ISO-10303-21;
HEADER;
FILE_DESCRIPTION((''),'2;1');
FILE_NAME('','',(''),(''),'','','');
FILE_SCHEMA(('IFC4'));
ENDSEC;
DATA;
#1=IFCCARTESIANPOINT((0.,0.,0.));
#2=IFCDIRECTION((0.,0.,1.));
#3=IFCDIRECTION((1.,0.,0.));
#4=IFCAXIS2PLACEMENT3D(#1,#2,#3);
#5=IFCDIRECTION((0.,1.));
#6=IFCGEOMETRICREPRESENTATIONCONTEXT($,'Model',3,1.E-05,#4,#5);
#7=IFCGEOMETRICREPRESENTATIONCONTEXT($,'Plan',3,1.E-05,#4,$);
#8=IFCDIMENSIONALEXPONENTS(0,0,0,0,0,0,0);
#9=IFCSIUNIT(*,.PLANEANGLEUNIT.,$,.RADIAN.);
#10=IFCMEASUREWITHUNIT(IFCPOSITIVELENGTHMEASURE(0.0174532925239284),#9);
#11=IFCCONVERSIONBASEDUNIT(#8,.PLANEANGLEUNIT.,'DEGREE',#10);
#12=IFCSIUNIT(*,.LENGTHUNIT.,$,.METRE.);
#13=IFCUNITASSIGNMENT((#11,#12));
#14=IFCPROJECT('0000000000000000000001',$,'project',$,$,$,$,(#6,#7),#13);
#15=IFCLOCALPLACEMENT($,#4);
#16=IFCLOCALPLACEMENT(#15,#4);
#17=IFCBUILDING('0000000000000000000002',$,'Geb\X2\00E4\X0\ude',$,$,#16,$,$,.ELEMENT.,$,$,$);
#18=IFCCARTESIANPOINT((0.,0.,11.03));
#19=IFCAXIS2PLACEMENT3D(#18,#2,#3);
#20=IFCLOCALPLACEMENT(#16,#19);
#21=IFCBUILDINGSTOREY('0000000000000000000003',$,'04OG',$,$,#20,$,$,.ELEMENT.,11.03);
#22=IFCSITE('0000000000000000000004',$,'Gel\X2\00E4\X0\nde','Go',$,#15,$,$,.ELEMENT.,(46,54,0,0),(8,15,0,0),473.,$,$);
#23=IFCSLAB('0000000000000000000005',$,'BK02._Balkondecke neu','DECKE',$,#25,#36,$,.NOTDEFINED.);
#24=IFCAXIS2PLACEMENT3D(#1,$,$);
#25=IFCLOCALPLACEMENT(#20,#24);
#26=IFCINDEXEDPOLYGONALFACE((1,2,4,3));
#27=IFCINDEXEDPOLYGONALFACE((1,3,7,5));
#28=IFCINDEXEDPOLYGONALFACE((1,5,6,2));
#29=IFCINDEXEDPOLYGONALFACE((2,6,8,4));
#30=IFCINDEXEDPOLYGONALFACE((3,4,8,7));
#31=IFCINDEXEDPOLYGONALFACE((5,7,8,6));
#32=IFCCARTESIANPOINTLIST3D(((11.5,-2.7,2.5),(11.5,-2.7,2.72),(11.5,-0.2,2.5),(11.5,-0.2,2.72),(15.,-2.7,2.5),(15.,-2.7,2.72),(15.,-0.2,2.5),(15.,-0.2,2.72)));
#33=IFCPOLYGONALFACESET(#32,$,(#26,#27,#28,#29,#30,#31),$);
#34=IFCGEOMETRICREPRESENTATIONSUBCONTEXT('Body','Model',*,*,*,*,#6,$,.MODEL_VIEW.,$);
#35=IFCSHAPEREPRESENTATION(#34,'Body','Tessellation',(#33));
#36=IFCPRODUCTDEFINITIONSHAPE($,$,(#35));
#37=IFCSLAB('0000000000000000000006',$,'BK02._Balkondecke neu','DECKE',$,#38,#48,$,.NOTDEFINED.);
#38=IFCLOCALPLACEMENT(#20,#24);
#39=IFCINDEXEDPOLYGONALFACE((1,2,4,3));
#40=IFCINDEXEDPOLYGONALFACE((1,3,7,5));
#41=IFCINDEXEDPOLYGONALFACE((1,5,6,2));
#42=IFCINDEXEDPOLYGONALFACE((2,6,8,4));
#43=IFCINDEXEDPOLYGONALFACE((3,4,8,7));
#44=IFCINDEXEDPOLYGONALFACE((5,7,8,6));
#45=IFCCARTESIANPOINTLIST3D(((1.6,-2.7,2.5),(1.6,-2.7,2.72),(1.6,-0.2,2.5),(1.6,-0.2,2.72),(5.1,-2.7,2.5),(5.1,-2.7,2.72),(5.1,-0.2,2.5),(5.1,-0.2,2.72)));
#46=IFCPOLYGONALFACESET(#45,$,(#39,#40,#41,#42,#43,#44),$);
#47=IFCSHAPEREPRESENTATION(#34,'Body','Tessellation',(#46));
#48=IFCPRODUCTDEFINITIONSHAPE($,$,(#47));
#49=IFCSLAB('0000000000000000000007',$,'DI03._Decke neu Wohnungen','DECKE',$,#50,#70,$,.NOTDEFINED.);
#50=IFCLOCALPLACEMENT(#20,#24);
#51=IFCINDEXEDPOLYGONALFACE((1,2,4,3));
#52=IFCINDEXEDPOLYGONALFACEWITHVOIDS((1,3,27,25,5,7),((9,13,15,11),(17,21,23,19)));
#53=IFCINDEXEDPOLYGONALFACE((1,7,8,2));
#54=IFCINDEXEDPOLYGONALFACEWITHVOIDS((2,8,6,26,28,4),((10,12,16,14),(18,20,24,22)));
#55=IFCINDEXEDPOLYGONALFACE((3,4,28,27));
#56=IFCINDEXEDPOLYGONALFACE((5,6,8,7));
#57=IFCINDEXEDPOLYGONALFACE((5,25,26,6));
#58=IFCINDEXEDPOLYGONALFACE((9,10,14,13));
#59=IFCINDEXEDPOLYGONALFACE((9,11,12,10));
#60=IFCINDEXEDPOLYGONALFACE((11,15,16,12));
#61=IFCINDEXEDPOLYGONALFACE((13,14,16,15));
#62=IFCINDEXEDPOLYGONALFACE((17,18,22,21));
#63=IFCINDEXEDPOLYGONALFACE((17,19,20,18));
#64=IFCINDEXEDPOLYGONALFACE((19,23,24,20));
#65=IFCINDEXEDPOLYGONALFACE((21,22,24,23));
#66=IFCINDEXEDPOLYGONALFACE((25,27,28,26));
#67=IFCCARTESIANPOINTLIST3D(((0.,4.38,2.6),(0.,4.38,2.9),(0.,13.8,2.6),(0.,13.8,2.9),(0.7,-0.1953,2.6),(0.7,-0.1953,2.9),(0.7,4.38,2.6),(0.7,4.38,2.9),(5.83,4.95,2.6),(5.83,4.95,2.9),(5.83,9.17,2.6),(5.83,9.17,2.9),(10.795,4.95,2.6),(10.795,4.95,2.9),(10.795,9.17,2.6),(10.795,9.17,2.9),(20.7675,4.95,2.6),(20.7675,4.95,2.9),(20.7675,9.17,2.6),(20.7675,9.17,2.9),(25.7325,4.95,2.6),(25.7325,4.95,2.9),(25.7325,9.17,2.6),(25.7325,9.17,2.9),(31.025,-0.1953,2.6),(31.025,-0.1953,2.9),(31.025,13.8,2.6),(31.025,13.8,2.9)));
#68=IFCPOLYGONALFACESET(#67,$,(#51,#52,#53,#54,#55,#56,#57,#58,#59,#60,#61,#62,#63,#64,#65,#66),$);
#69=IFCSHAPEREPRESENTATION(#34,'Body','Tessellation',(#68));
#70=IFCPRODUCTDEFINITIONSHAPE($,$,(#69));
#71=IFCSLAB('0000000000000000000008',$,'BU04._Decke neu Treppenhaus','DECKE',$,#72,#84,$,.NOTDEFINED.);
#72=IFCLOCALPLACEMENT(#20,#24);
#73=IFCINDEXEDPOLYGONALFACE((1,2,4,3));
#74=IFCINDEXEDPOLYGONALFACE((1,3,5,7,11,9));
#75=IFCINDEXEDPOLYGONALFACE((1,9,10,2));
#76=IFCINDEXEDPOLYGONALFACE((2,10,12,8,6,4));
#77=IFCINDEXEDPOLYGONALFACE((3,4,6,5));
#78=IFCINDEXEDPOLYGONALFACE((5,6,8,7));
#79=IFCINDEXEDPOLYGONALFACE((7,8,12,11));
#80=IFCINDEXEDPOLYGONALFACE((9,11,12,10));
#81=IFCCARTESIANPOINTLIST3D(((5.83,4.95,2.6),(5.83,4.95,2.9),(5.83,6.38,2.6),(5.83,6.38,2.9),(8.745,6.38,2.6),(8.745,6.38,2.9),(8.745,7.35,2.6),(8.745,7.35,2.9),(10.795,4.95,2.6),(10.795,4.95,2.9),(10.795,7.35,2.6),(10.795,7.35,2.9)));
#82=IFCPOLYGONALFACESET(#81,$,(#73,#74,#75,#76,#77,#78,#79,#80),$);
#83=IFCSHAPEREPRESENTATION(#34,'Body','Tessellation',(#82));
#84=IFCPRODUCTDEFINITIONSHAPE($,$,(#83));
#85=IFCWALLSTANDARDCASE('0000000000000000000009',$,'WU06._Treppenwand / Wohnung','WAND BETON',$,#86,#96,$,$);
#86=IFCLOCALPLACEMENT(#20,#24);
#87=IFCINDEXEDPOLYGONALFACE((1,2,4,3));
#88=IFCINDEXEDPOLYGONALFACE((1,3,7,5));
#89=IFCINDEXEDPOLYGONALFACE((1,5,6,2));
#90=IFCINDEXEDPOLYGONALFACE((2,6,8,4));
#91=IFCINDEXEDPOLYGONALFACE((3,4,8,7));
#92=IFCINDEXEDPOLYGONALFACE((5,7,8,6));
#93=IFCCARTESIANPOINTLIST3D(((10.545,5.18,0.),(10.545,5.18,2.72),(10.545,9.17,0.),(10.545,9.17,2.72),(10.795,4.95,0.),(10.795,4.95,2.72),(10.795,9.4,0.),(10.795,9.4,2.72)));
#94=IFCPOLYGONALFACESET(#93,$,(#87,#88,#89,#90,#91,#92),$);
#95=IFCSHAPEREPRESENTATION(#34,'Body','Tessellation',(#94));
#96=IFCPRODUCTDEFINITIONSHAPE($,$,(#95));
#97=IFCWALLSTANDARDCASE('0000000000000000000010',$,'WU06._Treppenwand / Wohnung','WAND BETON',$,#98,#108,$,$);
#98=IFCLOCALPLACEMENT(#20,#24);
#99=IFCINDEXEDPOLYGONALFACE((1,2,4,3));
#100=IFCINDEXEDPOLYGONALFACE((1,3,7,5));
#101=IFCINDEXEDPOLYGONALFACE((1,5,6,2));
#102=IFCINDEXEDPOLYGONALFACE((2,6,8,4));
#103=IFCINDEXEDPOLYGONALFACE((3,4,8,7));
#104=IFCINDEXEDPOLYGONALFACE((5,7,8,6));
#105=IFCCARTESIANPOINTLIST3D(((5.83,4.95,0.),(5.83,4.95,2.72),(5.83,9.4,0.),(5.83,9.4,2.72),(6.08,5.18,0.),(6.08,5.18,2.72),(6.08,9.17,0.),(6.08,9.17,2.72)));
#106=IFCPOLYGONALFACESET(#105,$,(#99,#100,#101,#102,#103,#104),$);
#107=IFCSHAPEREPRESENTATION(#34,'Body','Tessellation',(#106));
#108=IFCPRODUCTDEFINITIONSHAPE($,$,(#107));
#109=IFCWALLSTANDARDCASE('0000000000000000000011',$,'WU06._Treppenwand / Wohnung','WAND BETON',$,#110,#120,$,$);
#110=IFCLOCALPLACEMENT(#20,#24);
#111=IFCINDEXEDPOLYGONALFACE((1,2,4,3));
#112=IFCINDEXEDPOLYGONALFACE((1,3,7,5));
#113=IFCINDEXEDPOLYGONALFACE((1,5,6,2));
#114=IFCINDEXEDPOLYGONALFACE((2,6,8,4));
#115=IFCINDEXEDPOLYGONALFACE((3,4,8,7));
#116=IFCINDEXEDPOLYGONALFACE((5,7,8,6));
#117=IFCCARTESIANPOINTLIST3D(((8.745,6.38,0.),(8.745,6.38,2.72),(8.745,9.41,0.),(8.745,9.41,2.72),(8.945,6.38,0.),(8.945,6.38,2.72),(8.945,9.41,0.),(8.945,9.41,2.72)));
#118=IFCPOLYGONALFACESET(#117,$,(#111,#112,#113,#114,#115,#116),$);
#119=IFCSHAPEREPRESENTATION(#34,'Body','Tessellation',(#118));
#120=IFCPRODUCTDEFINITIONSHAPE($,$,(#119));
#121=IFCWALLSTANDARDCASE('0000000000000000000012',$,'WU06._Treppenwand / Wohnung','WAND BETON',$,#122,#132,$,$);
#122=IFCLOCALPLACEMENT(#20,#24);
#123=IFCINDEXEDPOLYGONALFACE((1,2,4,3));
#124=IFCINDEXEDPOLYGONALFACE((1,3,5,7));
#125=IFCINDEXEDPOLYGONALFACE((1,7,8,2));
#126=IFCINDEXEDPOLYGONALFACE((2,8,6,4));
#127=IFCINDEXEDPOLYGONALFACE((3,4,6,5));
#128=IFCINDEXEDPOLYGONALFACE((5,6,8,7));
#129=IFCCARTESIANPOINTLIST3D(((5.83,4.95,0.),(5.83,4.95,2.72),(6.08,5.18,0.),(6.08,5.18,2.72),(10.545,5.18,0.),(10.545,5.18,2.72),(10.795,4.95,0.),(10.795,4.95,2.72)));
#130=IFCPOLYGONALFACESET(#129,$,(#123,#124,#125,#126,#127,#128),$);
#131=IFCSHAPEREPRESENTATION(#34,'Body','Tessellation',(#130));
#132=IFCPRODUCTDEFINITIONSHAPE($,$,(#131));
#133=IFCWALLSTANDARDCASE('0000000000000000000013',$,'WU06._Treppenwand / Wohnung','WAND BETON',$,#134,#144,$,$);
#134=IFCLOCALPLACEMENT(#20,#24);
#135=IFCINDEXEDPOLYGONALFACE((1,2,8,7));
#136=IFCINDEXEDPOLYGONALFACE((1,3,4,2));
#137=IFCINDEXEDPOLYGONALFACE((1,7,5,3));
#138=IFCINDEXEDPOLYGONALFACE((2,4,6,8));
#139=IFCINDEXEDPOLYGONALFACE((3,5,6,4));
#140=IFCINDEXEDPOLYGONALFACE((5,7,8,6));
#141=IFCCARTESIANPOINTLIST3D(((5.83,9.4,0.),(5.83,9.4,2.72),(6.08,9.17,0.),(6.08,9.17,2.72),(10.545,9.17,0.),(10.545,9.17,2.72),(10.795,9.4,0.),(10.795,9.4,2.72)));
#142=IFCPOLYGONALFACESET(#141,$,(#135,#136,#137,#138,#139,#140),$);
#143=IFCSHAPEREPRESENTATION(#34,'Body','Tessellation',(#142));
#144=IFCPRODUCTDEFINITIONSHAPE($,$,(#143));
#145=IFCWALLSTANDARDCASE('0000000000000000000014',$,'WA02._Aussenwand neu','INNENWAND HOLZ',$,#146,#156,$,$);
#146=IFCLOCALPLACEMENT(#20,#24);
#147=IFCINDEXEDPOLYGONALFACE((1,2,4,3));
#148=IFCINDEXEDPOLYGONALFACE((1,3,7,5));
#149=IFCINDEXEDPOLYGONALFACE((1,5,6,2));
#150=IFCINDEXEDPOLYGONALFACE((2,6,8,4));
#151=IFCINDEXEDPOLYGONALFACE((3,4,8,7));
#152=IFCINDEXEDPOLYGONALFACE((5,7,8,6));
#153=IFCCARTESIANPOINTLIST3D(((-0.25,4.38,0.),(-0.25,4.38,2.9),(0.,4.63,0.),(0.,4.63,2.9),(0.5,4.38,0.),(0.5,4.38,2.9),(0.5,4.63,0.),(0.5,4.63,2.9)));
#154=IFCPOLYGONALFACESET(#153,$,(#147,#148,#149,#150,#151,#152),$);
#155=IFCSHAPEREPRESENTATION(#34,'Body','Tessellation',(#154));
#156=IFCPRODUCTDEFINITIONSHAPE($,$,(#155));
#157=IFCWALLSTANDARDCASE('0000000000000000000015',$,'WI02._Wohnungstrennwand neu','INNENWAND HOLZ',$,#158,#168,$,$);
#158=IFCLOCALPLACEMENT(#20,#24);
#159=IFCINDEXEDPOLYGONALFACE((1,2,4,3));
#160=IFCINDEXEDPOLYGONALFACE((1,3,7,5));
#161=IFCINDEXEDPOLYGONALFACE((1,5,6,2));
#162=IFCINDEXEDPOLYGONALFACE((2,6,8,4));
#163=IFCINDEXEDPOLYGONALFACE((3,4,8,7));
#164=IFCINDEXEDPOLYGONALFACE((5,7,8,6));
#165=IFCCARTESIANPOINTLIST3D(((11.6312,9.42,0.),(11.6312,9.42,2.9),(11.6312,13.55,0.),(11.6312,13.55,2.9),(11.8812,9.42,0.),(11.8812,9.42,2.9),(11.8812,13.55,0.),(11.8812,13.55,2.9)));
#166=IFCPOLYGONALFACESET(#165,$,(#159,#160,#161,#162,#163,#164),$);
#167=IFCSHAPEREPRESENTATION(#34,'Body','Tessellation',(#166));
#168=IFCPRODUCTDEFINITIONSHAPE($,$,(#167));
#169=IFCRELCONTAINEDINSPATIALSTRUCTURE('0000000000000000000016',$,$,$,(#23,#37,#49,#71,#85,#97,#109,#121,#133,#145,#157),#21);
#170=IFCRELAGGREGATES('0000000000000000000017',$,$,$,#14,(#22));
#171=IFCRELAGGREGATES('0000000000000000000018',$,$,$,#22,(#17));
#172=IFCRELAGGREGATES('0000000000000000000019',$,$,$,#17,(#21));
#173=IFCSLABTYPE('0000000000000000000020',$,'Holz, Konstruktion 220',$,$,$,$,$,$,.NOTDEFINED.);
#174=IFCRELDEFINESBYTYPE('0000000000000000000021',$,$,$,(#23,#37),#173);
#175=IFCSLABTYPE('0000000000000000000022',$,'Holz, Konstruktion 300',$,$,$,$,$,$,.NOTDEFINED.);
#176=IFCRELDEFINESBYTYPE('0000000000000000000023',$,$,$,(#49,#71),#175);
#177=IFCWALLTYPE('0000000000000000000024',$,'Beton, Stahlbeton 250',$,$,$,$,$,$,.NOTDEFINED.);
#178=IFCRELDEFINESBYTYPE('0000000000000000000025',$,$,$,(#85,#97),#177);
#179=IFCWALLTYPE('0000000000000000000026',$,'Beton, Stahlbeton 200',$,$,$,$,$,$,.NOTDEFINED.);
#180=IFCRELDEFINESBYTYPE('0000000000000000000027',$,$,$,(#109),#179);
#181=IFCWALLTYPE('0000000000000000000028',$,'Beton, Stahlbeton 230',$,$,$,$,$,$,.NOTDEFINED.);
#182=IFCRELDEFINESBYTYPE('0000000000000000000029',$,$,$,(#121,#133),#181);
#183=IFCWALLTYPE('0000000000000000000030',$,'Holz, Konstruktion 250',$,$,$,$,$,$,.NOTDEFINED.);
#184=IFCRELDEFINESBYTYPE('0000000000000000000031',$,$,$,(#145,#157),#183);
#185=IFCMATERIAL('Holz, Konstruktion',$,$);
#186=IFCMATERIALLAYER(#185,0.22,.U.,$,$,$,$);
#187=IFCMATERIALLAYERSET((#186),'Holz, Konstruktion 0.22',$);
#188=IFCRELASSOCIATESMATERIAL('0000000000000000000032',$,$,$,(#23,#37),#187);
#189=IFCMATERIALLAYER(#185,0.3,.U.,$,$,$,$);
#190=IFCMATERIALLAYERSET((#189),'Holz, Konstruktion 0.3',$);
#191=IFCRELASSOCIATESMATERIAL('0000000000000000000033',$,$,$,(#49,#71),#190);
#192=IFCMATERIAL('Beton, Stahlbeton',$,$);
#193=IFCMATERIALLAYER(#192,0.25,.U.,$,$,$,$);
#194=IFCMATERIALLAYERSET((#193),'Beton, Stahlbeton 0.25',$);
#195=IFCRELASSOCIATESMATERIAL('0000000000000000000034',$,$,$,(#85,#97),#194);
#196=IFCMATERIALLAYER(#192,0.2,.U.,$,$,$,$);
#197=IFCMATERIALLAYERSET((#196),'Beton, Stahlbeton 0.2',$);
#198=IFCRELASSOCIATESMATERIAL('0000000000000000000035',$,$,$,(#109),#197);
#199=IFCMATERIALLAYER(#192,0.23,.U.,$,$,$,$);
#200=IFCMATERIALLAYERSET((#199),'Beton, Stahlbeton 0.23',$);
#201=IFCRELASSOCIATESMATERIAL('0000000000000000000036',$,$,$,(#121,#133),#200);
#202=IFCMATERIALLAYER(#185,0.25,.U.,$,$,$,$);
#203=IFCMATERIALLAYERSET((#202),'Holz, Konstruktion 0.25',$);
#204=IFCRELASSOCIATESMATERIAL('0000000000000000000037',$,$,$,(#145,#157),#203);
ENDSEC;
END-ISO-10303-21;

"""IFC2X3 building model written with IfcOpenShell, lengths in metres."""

from ifc_helpers import new_model, entity, si_unit, converted_unit, direction, frame, origin_with_axes, place, context, subcontext, project, spatial, polyline, outline, extrude, material, layer, layer_set, layer_usage, type_object, element, save


model = new_model("IFC2X3")

# Units and contexts
model_context = context("Model", 3, precision=1e-05, world=origin_with_axes(), true_north=direction((0.0, 1.0)))
plan_context = context("Plan", 3, precision=1e-05, world=origin_with_axes())
body_context = subcontext(model_context, "Body", "Model", "MODEL_VIEW")
ifc_project = project(units=[converted_unit("PLANEANGLEUNIT", "DEGREE", entity("IfcPositiveLengthMeasure", 0.0174532925239284), si_unit("PLANEANGLEUNIT", "RADIAN"), dimensions=[0, 0, 0, 0, 0, 0, 0]), si_unit("LENGTHUNIT", "METRE")], contexts=[model_context, plan_context])

# Site, building, storey
site_placement = place(None, origin_with_axes())
site = spatial("IfcSite", under=ifc_project, at=site_placement, Name="Gelände", Description="Go", CompositionType="ELEMENT", RefLatitude=(46, 54, 0, 0), RefLongitude=(8, 15, 0, 0), RefElevation=473.0)
building_placement = place(site_placement, origin_with_axes())
building = spatial("IfcBuilding", under=site, at=building_placement, Name="Gebäude", CompositionType="ELEMENT")
storey_placement = place(building_placement, frame((0.0, 0.0, 11.03), z_axis=(0.0, 0.0, 1.0), x_axis=(1.0, 0.0, 0.0)))
storey = spatial("IfcBuildingStorey", under=building, at=storey_placement, Name="04OG", CompositionType="ELEMENT", Elevation=11.03)

# Slabs
ifc_material_1 = material(Name="Holz, Konstruktion")
ifc_layer_1 = layer(ifc_material_1, 0.22, ventilated="UNKNOWN")
ifc_layer_set_1 = layer_set([ifc_layer_1], Name="Holz, Konstruktion 0.22")
ifc_layer_usage_1 = layer_usage(ifc_layer_set_1, "AXIS3", "NEGATIVE", 0.22)
slab_type_1 = type_object("IfcSlabType", Name="Holz, Konstruktion 220", PredefinedType="NOTDEFINED")
slab_1_placement = place(storey_placement, frame((11.5, -2.7, 2.72), z_axis=(0.0, 0.0, 1.0), x_axis=(1.0, 0.0, 0.0)))
element("IfcSlab", 1, at=slab_1_placement, inside=storey, type_object=slab_type_1, material=ifc_layer_usage_1, Name="BK02._Balkondecke neu", Description="DECKE", PredefinedType="NOTDEFINED", context=body_context, shape_type="SweptSolid", body=[
    extrude(outline(polyline([(0.0, 0.0), (3.5, 0.0), (3.5, 2.5), (0.0, 2.5), (0.0, 0.0)])), frame((0.0, 0.0, -0.22), z_axis=(0.0, 0.0, 1.0), x_axis=(1.0, 0.0, 0.0)), (0.0, 0.0, 1.0), 0.22),
])
ifc_layer_usage_2 = layer_usage(ifc_layer_set_1, "AXIS3", "NEGATIVE", 0.22)
slab_2_placement = place(storey_placement, frame((1.6, -2.7, 2.72), z_axis=(0.0, 0.0, 1.0), x_axis=(1.0, 0.0, 0.0)))
element("IfcSlab", 2, at=slab_2_placement, inside=storey, type_object=slab_type_1, material=ifc_layer_usage_2, Name="BK02._Balkondecke neu", Description="DECKE", PredefinedType="NOTDEFINED", context=body_context, shape_type="SweptSolid", body=[
    extrude(outline(polyline([(0.0, 0.0), (3.5, 0.0), (3.5, 2.5), (0.0, 2.5), (0.0, 0.0)])), frame((0.0, 0.0, -0.22), z_axis=(0.0, 0.0, 1.0), x_axis=(1.0, 0.0, 0.0)), (0.0, 0.0, 1.0), 0.22),
])
ifc_layer_2 = layer(ifc_material_1, 0.3, ventilated="UNKNOWN")
ifc_layer_set_2 = layer_set([ifc_layer_2], Name="Holz, Konstruktion 0.3")
ifc_layer_usage_3 = layer_usage(ifc_layer_set_2, "AXIS3", "NEGATIVE", 0.3)
slab_type_2 = type_object("IfcSlabType", Name="Holz, Konstruktion 300", PredefinedType="NOTDEFINED")
slab_3_placement = place(storey_placement, frame((0.0, 13.8, 2.9), z_axis=(0.0, 0.0, 1.0), x_axis=(1.0, 0.0, 0.0)))
element("IfcSlab", 3, at=slab_3_placement, inside=storey, type_object=slab_type_2, material=ifc_layer_usage_3, Name="DI03._Decke neu Wohnungen", Description="DECKE", PredefinedType="NOTDEFINED", context=body_context, shape_type="SweptSolid", body=[
    extrude(outline(polyline([(0.0, 0.0), (0.0, -9.42), (0.7, -9.42), (0.7, -13.9953), (31.025, -13.9953), (31.025, 0.0), (0.0, 0.0)]), holes=[polyline([(5.83, -8.85), (5.83, -4.63), (10.795, -4.63), (10.795, -8.85), (5.83, -8.85)]), polyline([(20.7675, -8.85), (20.7675, -4.63), (25.7325, -4.63), (25.7325, -8.85), (20.7675, -8.85)])]), frame((0.0, 0.0, -0.3), z_axis=(0.0, 0.0, 1.0), x_axis=(1.0, 0.0, 0.0)), (0.0, 0.0, 1.0), 0.3),
])
ifc_layer_usage_4 = layer_usage(ifc_layer_set_2, "AXIS3", "NEGATIVE", 0.3)
slab_4_placement = place(storey_placement, frame((10.795, 7.35, 2.9), z_axis=(0.0, 0.0, 1.0), x_axis=(1.0, 0.0, 0.0)))
element("IfcSlab", 4, at=slab_4_placement, inside=storey, type_object=slab_type_2, material=ifc_layer_usage_4, Name="BU04._Decke neu Treppenhaus", Description="DECKE", PredefinedType="NOTDEFINED", context=body_context, shape_type="SweptSolid", body=[
    extrude(outline(polyline([(0.0, 0.0), (-2.05, 0.0), (-2.05, -0.97), (-4.965, -0.97), (-4.965, -2.4), (0.0, -2.4), (0.0, 0.0)])), frame((0.0, 0.0, -0.3), z_axis=(0.0, 0.0, 1.0), x_axis=(1.0, 0.0, 0.0)), (0.0, 0.0, 1.0), 0.3),
])

# Walls
ifc_material_2 = material(Name="Beton, Stahlbeton")
ifc_layer_3 = layer(ifc_material_2, 0.25, ventilated="UNKNOWN")
ifc_layer_set_3 = layer_set([ifc_layer_3], Name="Beton, Stahlbeton 0.25")
ifc_layer_usage_5 = layer_usage(ifc_layer_set_3, "AXIS2", "POSITIVE", -0.25)
wall_type_1 = type_object("IfcWallType", Name="Beton, Stahlbeton 250", PredefinedType="NOTDEFINED")
wall_1_placement = place(storey_placement, frame((10.545, 5.18, 0.0), z_axis=(0.0, 0.0, 1.0), x_axis=(0.0, 1.0, 0.0)))
element("IfcWallStandardCase", 5, at=wall_1_placement, inside=storey, type_object=wall_type_1, material=ifc_layer_usage_5, Name="WU06._Treppenwand / Wohnung", Description="WAND BETON", context=body_context, shape_type="SweptSolid", body=[
    extrude(outline(polyline([(-0.23, -0.25), (4.22, -0.25), (3.99, 0.0), (0.0, 0.0), (-0.23, -0.25)])), origin_with_axes(), (0.0, 0.0, 1.0), 2.72),
])
ifc_layer_usage_6 = layer_usage(ifc_layer_set_3, "AXIS2", "POSITIVE", -0.25)
wall_2_placement = place(storey_placement, frame((6.08, 9.17, 0.0), z_axis=(0.0, 0.0, 1.0), x_axis=(0.0, -1.0, 0.0)))
element("IfcWallStandardCase", 6, at=wall_2_placement, inside=storey, type_object=wall_type_1, material=ifc_layer_usage_6, Name="WU06._Treppenwand / Wohnung", Description="WAND BETON", context=body_context, shape_type="SweptSolid", body=[
    extrude(outline(polyline([(-0.23, -0.25), (4.22, -0.25), (3.99, 0.0), (0.0, 0.0), (-0.23, -0.25)])), origin_with_axes(), (0.0, 0.0, 1.0), 2.72),
])
ifc_layer_4 = layer(ifc_material_2, 0.2, ventilated="UNKNOWN")
ifc_layer_set_4 = layer_set([ifc_layer_4], Name="Beton, Stahlbeton 0.2")
ifc_layer_usage_7 = layer_usage(ifc_layer_set_4, "AXIS2", "NEGATIVE", 0.2)
wall_type_2 = type_object("IfcWallType", Name="Beton, Stahlbeton 200", PredefinedType="NOTDEFINED")
wall_3_placement = place(storey_placement, frame((8.945, 6.38, 0.0), z_axis=(0.0, 0.0, 1.0), x_axis=(0.0, 1.0, 0.0)))
element("IfcWallStandardCase", 7, at=wall_3_placement, inside=storey, type_object=wall_type_2, material=ifc_layer_usage_7, Name="WU06._Treppenwand / Wohnung", Description="WAND BETON", context=body_context, shape_type="SweptSolid", body=[
    extrude(outline(polyline([(0.0, 0.0), (3.03, 0.0), (3.03, 0.2), (0.0, 0.2), (0.0, 0.0)])), origin_with_axes(), (0.0, 0.0, 1.0), 2.72),
])
ifc_layer_5 = layer(ifc_material_2, 0.23, ventilated="UNKNOWN")
ifc_layer_set_5 = layer_set([ifc_layer_5], Name="Beton, Stahlbeton 0.23")
ifc_layer_usage_8 = layer_usage(ifc_layer_set_5, "AXIS2", "POSITIVE", -0.23)
wall_type_3 = type_object("IfcWallType", Name="Beton, Stahlbeton 230", PredefinedType="NOTDEFINED")
wall_4_placement = place(storey_placement, frame((6.08, 5.18, 0.0), z_axis=(0.0, 0.0, 1.0), x_axis=(1.0, 0.0, 0.0)))
element("IfcWallStandardCase", 8, at=wall_4_placement, inside=storey, type_object=wall_type_3, material=ifc_layer_usage_8, Name="WU06._Treppenwand / Wohnung", Description="WAND BETON", context=body_context, shape_type="SweptSolid", body=[
    extrude(outline(polyline([(-0.25, -0.23), (4.715, -0.23), (4.465, 0.0), (0.0, 0.0), (-0.25, -0.23)])), origin_with_axes(), (0.0, 0.0, 1.0), 2.72),
])
ifc_layer_usage_9 = layer_usage(ifc_layer_set_5, "AXIS2", "POSITIVE", -0.23)
wall_5_placement = place(storey_placement, frame((10.545, 9.17, 0.0), z_axis=(0.0, 0.0, 1.0), x_axis=(-1.0, 0.0, 0.0)))
element("IfcWallStandardCase", 9, at=wall_5_placement, inside=storey, type_object=wall_type_3, material=ifc_layer_usage_9, Name="WU06._Treppenwand / Wohnung", Description="WAND BETON", context=body_context, shape_type="SweptSolid", body=[
    extrude(outline(polyline([(-0.25, -0.23), (4.715, -0.23), (4.465, 0.0), (0.0, 0.0), (-0.25, -0.23)])), origin_with_axes(), (0.0, 0.0, 1.0), 2.72),
])
ifc_layer_6 = layer(ifc_material_1, 0.25, ventilated="UNKNOWN")
ifc_layer_set_6 = layer_set([ifc_layer_6], Name="Holz, Konstruktion 0.25")
ifc_layer_usage_10 = layer_usage(ifc_layer_set_6, "AXIS2", "POSITIVE", 0.0)
wall_type_4 = type_object("IfcWallType", Name="Holz, Konstruktion 250", PredefinedType="NOTDEFINED")
wall_6_placement = place(storey_placement, frame((-0.25, 4.38, 0.0), z_axis=(0.0, 0.0, 1.0), x_axis=(1.0, 0.0, 0.0)))
element("IfcWallStandardCase", 10, at=wall_6_placement, inside=storey, type_object=wall_type_4, material=ifc_layer_usage_10, Name="WA02._Aussenwand neu", Description="INNENWAND HOLZ", context=body_context, shape_type="SweptSolid", body=[
    extrude(outline(polyline([(0.0, 0.0), (0.75, 0.0), (0.75, 0.25), (0.25, 0.25), (0.0, 0.0)])), origin_with_axes(), (0.0, 0.0, 1.0), 2.9),
])
ifc_layer_usage_11 = layer_usage(ifc_layer_set_6, "AXIS2", "NEGATIVE", 0.0)
wall_7_placement = place(storey_placement, frame((11.8812, 13.55, 0.0), z_axis=(0.0, 0.0, 1.0), x_axis=(0.0, -1.0, 0.0)))
element("IfcWallStandardCase", 11, at=wall_7_placement, inside=storey, type_object=wall_type_4, material=ifc_layer_usage_11, Name="WI02._Wohnungstrennwand neu", Description="INNENWAND HOLZ", context=body_context, shape_type="SweptSolid", body=[
    extrude(outline(polyline([(0.0, -0.25), (4.13, -0.25), (4.13, 0.0), (0.0, 0.0), (0.0, -0.25)])), origin_with_axes(), (0.0, 0.0, 1.0), 2.9),
])

save(model, "model.ifc")
